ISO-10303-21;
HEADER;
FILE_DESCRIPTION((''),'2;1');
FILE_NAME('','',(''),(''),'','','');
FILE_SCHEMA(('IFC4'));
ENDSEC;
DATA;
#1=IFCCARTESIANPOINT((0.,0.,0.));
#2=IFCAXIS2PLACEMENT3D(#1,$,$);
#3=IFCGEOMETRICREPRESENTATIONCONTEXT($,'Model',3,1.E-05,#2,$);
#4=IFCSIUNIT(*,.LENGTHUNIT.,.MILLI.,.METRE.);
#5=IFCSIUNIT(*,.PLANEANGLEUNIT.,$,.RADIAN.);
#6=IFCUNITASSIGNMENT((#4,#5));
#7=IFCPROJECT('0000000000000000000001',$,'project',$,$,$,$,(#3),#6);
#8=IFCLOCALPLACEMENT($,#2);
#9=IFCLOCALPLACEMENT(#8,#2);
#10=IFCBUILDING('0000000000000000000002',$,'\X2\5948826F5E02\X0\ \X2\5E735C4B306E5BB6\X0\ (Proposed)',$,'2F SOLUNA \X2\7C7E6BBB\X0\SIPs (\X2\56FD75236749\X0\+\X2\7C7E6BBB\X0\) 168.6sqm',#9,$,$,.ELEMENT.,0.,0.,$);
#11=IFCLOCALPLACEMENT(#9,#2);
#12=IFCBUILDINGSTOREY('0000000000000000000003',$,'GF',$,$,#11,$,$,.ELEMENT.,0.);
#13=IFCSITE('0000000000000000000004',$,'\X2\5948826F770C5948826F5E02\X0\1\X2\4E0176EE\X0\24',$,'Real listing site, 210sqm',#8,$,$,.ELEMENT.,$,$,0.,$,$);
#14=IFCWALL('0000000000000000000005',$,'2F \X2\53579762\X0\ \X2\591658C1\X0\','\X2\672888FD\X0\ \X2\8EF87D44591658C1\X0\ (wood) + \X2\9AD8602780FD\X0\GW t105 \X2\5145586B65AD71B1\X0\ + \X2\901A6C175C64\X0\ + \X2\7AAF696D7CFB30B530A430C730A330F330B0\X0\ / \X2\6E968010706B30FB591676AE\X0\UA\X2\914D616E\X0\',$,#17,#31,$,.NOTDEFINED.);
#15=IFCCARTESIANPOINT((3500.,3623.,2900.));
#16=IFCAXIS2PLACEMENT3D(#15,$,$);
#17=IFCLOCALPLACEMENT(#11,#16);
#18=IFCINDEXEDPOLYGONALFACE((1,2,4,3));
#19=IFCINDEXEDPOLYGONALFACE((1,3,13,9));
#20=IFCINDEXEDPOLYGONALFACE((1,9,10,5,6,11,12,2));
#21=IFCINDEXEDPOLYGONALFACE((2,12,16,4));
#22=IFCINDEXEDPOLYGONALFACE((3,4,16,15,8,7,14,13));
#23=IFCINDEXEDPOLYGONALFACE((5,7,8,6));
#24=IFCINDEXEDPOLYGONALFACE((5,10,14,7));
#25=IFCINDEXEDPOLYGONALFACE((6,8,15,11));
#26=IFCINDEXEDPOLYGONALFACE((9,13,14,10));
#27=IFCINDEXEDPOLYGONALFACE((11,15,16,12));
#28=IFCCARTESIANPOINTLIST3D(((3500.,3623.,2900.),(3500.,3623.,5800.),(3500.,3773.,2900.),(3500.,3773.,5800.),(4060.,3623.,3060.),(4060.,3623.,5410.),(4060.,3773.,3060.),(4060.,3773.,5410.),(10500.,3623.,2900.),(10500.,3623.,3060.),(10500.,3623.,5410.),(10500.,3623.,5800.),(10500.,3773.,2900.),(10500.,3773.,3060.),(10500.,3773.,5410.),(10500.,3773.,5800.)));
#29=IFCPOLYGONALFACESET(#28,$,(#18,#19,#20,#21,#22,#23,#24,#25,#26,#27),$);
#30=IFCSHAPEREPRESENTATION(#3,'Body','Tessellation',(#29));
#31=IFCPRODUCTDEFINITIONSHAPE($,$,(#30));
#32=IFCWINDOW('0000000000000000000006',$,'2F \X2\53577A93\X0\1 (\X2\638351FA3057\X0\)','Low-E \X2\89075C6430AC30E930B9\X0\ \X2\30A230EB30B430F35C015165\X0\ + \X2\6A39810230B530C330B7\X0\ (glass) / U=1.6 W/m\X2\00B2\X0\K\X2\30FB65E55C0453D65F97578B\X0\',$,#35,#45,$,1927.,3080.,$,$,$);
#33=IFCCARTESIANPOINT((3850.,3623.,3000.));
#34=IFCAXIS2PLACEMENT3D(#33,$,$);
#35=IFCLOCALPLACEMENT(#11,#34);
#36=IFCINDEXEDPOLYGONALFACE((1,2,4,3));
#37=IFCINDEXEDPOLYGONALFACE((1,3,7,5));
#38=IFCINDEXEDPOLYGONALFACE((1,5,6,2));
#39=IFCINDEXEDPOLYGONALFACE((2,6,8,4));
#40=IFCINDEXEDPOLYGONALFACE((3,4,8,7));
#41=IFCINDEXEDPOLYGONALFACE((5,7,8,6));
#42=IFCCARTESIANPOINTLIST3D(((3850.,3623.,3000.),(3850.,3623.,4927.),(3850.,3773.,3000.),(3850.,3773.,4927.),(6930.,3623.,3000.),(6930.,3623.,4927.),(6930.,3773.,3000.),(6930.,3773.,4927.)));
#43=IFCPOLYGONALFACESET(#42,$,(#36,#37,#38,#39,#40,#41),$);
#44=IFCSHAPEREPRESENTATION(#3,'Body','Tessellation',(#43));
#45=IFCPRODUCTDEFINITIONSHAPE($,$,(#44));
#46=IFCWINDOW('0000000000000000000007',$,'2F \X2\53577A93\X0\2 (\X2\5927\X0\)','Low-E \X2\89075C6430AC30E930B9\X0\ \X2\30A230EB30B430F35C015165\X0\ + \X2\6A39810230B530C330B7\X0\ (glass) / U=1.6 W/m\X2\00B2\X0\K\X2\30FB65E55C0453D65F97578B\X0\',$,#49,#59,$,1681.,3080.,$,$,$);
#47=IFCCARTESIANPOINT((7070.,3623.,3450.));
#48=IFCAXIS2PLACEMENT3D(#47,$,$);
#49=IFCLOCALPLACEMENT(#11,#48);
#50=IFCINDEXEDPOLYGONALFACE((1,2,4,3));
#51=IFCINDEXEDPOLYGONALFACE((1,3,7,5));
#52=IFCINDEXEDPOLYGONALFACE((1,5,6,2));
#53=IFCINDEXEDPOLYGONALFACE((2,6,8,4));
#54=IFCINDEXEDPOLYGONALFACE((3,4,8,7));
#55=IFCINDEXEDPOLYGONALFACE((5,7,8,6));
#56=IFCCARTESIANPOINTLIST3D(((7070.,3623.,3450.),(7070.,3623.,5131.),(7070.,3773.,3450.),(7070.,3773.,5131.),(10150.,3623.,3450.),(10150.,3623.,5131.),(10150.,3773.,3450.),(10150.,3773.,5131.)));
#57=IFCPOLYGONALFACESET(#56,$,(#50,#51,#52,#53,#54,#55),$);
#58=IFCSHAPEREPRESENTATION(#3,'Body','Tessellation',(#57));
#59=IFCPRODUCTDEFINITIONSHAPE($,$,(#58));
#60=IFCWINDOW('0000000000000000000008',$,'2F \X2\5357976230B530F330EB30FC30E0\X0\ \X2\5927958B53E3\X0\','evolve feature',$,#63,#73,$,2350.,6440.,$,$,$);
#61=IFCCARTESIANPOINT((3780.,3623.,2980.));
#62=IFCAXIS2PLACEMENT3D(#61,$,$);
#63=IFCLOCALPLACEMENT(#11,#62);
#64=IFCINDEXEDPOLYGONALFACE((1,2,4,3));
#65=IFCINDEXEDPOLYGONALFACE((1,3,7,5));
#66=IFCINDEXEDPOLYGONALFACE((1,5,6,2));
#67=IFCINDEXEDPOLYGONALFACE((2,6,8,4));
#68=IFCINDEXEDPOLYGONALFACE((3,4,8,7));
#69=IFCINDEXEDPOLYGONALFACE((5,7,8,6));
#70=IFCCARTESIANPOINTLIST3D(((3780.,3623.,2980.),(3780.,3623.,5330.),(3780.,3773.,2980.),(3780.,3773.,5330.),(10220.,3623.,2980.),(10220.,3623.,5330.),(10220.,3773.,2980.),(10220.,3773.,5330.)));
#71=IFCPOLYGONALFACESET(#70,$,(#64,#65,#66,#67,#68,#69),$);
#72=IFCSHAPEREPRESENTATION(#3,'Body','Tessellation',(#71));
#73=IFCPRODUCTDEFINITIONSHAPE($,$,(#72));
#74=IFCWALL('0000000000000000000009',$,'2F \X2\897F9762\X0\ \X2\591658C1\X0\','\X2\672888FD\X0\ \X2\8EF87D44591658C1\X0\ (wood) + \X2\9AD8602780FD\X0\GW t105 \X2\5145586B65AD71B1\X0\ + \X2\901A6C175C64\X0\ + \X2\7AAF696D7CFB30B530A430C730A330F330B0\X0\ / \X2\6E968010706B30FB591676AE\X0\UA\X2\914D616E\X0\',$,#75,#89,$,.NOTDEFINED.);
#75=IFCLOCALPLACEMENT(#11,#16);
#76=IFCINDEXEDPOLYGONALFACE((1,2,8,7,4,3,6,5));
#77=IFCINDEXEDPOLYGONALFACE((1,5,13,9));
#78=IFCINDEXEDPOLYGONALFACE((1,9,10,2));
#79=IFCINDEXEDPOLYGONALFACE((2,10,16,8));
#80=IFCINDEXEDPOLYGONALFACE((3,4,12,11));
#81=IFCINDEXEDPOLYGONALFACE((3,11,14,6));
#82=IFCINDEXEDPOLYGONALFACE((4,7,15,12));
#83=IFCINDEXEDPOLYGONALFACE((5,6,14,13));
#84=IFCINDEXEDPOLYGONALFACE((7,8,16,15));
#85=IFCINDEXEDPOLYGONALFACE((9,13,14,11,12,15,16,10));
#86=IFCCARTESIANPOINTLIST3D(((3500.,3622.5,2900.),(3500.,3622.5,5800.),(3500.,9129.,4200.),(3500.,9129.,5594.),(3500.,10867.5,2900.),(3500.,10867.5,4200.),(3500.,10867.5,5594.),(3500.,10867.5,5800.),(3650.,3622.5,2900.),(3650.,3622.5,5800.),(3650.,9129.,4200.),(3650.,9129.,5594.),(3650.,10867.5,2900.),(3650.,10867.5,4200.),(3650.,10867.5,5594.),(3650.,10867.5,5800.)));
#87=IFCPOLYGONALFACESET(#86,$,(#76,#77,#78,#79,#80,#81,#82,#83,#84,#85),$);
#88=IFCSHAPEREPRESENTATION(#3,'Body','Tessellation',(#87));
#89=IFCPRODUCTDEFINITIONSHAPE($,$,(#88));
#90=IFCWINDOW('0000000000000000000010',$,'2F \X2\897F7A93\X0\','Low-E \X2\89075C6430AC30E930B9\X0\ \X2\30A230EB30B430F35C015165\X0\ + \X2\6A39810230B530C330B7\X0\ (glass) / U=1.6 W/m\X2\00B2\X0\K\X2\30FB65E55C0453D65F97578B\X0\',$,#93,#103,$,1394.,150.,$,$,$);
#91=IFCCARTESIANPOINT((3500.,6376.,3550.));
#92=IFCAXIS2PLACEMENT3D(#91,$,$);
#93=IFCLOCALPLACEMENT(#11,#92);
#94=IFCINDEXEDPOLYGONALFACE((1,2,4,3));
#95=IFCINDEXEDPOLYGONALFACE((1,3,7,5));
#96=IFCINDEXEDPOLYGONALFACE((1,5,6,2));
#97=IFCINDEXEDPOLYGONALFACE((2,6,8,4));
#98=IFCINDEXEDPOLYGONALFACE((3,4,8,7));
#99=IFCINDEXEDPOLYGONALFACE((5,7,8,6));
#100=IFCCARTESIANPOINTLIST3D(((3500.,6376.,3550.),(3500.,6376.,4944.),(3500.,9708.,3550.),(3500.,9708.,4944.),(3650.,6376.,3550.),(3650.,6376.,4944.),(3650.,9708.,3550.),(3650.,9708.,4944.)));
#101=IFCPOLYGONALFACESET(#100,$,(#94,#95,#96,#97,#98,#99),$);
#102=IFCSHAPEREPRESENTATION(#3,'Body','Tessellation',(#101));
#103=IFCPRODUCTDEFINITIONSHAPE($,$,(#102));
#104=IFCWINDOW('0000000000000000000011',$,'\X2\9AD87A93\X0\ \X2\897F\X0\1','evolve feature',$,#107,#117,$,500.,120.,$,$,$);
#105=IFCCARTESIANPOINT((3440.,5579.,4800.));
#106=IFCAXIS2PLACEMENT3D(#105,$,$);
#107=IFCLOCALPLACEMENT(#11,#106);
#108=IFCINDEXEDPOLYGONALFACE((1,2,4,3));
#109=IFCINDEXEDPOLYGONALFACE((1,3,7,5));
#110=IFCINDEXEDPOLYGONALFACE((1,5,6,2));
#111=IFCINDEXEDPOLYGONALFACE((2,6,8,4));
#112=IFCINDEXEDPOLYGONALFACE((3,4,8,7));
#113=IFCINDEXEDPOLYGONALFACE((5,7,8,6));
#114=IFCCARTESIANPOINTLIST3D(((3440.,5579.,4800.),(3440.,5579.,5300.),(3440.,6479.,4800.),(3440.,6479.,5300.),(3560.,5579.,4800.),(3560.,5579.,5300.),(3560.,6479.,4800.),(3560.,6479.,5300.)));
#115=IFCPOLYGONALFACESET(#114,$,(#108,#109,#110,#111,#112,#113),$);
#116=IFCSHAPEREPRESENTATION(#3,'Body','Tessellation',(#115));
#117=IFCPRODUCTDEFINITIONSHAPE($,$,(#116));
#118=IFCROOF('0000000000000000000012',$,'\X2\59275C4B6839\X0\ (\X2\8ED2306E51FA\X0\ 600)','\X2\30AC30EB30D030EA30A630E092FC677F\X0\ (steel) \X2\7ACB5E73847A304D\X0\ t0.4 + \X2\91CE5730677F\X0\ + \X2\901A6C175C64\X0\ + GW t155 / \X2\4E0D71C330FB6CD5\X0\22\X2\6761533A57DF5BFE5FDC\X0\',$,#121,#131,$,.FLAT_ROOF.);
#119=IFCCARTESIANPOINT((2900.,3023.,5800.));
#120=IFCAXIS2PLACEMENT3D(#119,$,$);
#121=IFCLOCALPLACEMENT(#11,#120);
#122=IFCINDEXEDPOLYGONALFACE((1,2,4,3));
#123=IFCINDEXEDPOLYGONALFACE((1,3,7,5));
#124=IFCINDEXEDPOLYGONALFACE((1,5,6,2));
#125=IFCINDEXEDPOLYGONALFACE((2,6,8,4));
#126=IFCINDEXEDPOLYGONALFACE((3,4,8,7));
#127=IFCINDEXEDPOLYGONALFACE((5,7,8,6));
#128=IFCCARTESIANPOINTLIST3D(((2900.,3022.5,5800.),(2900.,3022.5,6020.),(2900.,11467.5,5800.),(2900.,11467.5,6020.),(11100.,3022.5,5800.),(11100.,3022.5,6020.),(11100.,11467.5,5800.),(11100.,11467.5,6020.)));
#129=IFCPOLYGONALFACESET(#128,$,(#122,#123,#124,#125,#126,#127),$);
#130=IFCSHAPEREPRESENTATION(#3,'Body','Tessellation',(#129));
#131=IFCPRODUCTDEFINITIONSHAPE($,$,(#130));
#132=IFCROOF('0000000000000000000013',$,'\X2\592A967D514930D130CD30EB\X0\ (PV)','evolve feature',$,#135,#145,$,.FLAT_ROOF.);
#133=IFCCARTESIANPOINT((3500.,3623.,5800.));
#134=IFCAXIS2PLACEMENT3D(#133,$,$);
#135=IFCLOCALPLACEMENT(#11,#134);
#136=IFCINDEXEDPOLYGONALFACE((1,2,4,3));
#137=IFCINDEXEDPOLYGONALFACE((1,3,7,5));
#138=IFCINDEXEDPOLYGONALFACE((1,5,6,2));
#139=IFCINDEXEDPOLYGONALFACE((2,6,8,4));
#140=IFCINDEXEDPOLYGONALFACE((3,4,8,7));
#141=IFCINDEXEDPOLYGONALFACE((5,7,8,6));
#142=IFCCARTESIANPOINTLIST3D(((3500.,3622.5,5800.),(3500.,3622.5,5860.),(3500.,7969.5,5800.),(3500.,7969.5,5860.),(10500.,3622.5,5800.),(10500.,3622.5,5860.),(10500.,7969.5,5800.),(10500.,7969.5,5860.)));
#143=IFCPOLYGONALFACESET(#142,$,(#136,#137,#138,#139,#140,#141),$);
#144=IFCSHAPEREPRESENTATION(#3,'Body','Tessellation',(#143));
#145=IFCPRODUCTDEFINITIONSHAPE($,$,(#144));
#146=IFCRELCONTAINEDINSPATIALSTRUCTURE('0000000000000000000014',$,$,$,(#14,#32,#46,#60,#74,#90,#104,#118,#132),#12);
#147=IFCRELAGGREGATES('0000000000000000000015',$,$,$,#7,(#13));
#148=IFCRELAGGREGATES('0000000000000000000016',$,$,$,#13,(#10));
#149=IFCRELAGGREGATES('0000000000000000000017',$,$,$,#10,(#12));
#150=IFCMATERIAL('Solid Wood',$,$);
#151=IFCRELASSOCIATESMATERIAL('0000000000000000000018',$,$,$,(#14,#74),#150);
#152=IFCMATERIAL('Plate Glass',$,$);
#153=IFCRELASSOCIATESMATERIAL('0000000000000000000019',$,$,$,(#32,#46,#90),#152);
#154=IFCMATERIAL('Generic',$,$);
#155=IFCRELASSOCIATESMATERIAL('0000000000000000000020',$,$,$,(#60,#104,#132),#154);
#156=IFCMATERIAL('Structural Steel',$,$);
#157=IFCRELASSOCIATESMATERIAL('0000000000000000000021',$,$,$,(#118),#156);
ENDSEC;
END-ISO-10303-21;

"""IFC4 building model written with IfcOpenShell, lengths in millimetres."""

from ifc_helpers import new_model, si_unit, frame, frame_2d, origin, place, context, project, spatial, rectangle, extrude, material, element, fill, save


model = new_model("IFC4")

# Units and contexts
model_context = context("Model", 3, precision=1e-05, world=origin())
ifc_project = project(units=[si_unit("LENGTHUNIT", "METRE", prefix="MILLI"), si_unit("PLANEANGLEUNIT", "RADIAN")], contexts=[model_context])

# Site, building, storey
site_placement = place(None, origin())
site = spatial("IfcSite", under=ifc_project, at=site_placement, Name="奈良県奈良市1丁目24", ObjectType="Real listing site, 210sqm", CompositionType="ELEMENT", RefElevation=0.0)
building_placement = place(site_placement, origin())
building = spatial("IfcBuilding", under=site, at=building_placement, Name="奈良市 平屋の家 (Proposed)", ObjectType="2F SOLUNA 籾殻SIPs (国産杉+籾殻) 168.6sqm", CompositionType="ELEMENT", ElevationOfRefHeight=0.0, ElevationOfTerrain=0.0)
storey_placement = place(building_placement, origin())
storey = spatial("IfcBuildingStorey", under=building, at=storey_placement, Name="GF", CompositionType="ELEMENT", Elevation=0.0)

# Shared definitions
ifc_material_1 = material(Name="Solid Wood")
ifc_material_2 = material(Name="Generic")

# Shared definitions
ifc_material_3 = material(Name="Plate Glass")

# Walls, openings, windows
wall_1_placement = place(storey_placement, frame((3500.0, 3623.0, 2900.0)))
wall_1 = element("IfcWall", 1, at=wall_1_placement, inside=storey, material=ifc_material_1, Name="2F 南面 外壁", Description="木製 軸組外壁 (wood) + 高性能GW t105 充填断熱 + 通気層 + 窯業系サイディング / 準耐火・外皮UA配慮", PredefinedType="NOTDEFINED", context=model_context, shape_type="SweptSolid", body=[
    extrude(rectangle(XDim=7000.0, YDim=150.0, at=frame_2d((3500.0, 75.0))), frame((3500.0, 3623.0, 2900.0)), (0.0, 0.0, 1.0), 2900.0),
])
opening_1_placement = place(storey_placement, frame((3850.0, 3623.0, 3000.0)))
opening_1 = element("IfcOpeningElement", 2, at=opening_1_placement, cuts=wall_1, PredefinedType="NOTDEFINED", context=model_context, shape_type="SweptSolid", body=[
    extrude(rectangle(XDim=3080.0, YDim=150.0, at=frame_2d((1540.0, 75.0))), frame((3850.0, 3623.0, 3000.0)), (0.0, 0.0, 1.0), 1927.0),
])
opening_2_placement = place(storey_placement, frame((7070.0, 3623.0, 3450.0)))
opening_2 = element("IfcOpeningElement", 3, at=opening_2_placement, cuts=wall_1, PredefinedType="NOTDEFINED", context=model_context, shape_type="SweptSolid", body=[
    extrude(rectangle(XDim=3080.0, YDim=150.0, at=frame_2d((1540.0, 75.0))), frame((7070.0, 3623.0, 3450.0)), (0.0, 0.0, 1.0), 1681.0),
])
opening_3_placement = place(storey_placement, frame((3780.0, 3623.0, 2980.0)))
opening_3 = element("IfcOpeningElement", 4, at=opening_3_placement, cuts=wall_1, PredefinedType="NOTDEFINED", context=model_context, shape_type="SweptSolid", body=[
    extrude(rectangle(XDim=6440.0, YDim=150.0, at=frame_2d((3220.0, 75.0))), frame((3780.0, 3623.0, 2980.0)), (0.0, 0.0, 1.0), 2350.0),
])
window_1_placement = place(storey_placement, frame((3850.0, 3623.0, 3000.0)))
window_1 = element("IfcWindow", 5, at=window_1_placement, inside=storey, material=ifc_material_3, Name="2F 南窓1 (掃出し)", Description="Low-E 複層ガラス アルゴン封入 + 樹脂サッシ (glass) / U=1.6 W/m²K・日射取得型", OverallHeight=1927.0, OverallWidth=3080.0, context=model_context, shape_type="SweptSolid", body=[
    extrude(rectangle(XDim=3080.0, YDim=150.0, at=frame_2d((1540.0, 75.0))), frame((3850.0, 3623.0, 3000.0)), (0.0, 0.0, 1.0), 1927.0),
])
fill(opening_1, window_1)
window_2_placement = place(storey_placement, frame((7070.0, 3623.0, 3450.0)))
window_2 = element("IfcWindow", 6, at=window_2_placement, inside=storey, material=ifc_material_3, Name="2F 南窓2 (大)", Description="Low-E 複層ガラス アルゴン封入 + 樹脂サッシ (glass) / U=1.6 W/m²K・日射取得型", OverallHeight=1681.0, OverallWidth=3080.0, context=model_context, shape_type="SweptSolid", body=[
    extrude(rectangle(XDim=3080.0, YDim=150.0, at=frame_2d((1540.0, 75.0))), frame((7070.0, 3623.0, 3450.0)), (0.0, 0.0, 1.0), 1681.0),
])
fill(opening_2, window_2)
window_3_placement = place(storey_placement, frame((3780.0, 3623.0, 2980.0)))
window_3 = element("IfcWindow", 7, at=window_3_placement, inside=storey, material=ifc_material_2, Name="2F 南面サンルーム 大開口", Description="evolve feature", OverallHeight=2350.0, OverallWidth=6440.0, context=model_context, shape_type="SweptSolid", body=[
    extrude(rectangle(XDim=6440.0, YDim=150.0, at=frame_2d((3220.0, 75.0))), frame((3780.0, 3623.0, 2980.0)), (0.0, 0.0, 1.0), 2350.0),
])
fill(opening_3, window_3)
wall_2_placement = place(storey_placement, frame((3500.0, 3623.0, 2900.0)))
wall_2 = element("IfcWall", 8, at=wall_2_placement, inside=storey, material=ifc_material_1, Name="2F 西面 外壁", Description="木製 軸組外壁 (wood) + 高性能GW t105 充填断熱 + 通気層 + 窯業系サイディング / 準耐火・外皮UA配慮", PredefinedType="NOTDEFINED", context=model_context, shape_type="SweptSolid", body=[
    extrude(rectangle(XDim=150.0, YDim=7245.0, at=frame_2d((75.0, 3622.0))), frame((3500.0, 3623.0, 2900.0)), (0.0, 0.0, 1.0), 2900.0),
])
opening_4_placement = place(storey_placement, frame((3500.0, 6376.0, 3550.0)))
opening_4 = element("IfcOpeningElement", 9, at=opening_4_placement, cuts=wall_2, PredefinedType="NOTDEFINED", context=model_context, shape_type="SweptSolid", body=[
    extrude(rectangle(XDim=150.0, YDim=3332.0, at=frame_2d((75.0, 1666.0))), frame((3500.0, 6376.0, 3550.0)), (0.0, 0.0, 1.0), 1394.0),
])
opening_5_placement = place(storey_placement, frame((3440.0, 5579.0, 4800.0)))
opening_5 = element("IfcOpeningElement", 10, at=opening_5_placement, cuts=wall_2, PredefinedType="NOTDEFINED", context=model_context, shape_type="SweptSolid", body=[
    extrude(rectangle(XDim=120.0, YDim=900.0, at=frame_2d((60.0, 450.0))), frame((3440.0, 5579.0, 4800.0)), (0.0, 0.0, 1.0), 500.0),
])
window_4_placement = place(storey_placement, frame((3500.0, 6376.0, 3550.0)))
window_4 = element("IfcWindow", 11, at=window_4_placement, inside=storey, material=ifc_material_3, Name="2F 西窓", Description="Low-E 複層ガラス アルゴン封入 + 樹脂サッシ (glass) / U=1.6 W/m²K・日射取得型", OverallHeight=1394.0, OverallWidth=150.0, context=model_context, shape_type="SweptSolid", body=[
    extrude(rectangle(XDim=150.0, YDim=3332.0, at=frame_2d((75.0, 1666.0))), frame((3500.0, 6376.0, 3550.0)), (0.0, 0.0, 1.0), 1394.0),
])
fill(opening_4, window_4)
window_5_placement = place(storey_placement, frame((3440.0, 5579.0, 4800.0)))
window_5 = element("IfcWindow", 12, at=window_5_placement, inside=storey, material=ifc_material_2, Name="高窓 西1", Description="evolve feature", OverallHeight=500.0, OverallWidth=120.0, context=model_context, shape_type="SweptSolid", body=[
    extrude(rectangle(XDim=120.0, YDim=900.0, at=frame_2d((60.0, 450.0))), frame((3440.0, 5579.0, 4800.0)), (0.0, 0.0, 1.0), 500.0),
])
fill(opening_5, window_5)

# Roofs
ifc_material_4 = material(Name="Structural Steel")
roof_1_placement = place(storey_placement, frame((2900.0, 3023.0, 5800.0)))
element("IfcRoof", 13, at=roof_1_placement, inside=storey, material=ifc_material_4, Name="大屋根 (軒の出 600)", Description="ガルバリウム鋼板 (steel) 立平葺き t0.4 + 野地板 + 通気層 + GW t155 / 不燃・法22条区域対応", PredefinedType="FLAT_ROOF", context=model_context, shape_type="SweptSolid", body=[
    extrude(rectangle(XDim=8200.0, YDim=8445.0, at=frame_2d((4100.0, 4222.0))), frame((2900.0, 3023.0, 5800.0)), (0.0, 0.0, 1.0), 220.0),
])
roof_2_placement = place(storey_placement, frame((3500.0, 3623.0, 5800.0)))
element("IfcRoof", 14, at=roof_2_placement, inside=storey, material=ifc_material_2, Name="太陽光パネル (PV)", Description="evolve feature", PredefinedType="FLAT_ROOF", context=model_context, shape_type="SweptSolid", body=[
    extrude(rectangle(XDim=7000.0, YDim=4347.0, at=frame_2d((3500.0, 2173.0))), frame((3500.0, 3623.0, 5800.0)), (0.0, 0.0, 1.0), 60.0),
])

save(model, "model.ifc")
